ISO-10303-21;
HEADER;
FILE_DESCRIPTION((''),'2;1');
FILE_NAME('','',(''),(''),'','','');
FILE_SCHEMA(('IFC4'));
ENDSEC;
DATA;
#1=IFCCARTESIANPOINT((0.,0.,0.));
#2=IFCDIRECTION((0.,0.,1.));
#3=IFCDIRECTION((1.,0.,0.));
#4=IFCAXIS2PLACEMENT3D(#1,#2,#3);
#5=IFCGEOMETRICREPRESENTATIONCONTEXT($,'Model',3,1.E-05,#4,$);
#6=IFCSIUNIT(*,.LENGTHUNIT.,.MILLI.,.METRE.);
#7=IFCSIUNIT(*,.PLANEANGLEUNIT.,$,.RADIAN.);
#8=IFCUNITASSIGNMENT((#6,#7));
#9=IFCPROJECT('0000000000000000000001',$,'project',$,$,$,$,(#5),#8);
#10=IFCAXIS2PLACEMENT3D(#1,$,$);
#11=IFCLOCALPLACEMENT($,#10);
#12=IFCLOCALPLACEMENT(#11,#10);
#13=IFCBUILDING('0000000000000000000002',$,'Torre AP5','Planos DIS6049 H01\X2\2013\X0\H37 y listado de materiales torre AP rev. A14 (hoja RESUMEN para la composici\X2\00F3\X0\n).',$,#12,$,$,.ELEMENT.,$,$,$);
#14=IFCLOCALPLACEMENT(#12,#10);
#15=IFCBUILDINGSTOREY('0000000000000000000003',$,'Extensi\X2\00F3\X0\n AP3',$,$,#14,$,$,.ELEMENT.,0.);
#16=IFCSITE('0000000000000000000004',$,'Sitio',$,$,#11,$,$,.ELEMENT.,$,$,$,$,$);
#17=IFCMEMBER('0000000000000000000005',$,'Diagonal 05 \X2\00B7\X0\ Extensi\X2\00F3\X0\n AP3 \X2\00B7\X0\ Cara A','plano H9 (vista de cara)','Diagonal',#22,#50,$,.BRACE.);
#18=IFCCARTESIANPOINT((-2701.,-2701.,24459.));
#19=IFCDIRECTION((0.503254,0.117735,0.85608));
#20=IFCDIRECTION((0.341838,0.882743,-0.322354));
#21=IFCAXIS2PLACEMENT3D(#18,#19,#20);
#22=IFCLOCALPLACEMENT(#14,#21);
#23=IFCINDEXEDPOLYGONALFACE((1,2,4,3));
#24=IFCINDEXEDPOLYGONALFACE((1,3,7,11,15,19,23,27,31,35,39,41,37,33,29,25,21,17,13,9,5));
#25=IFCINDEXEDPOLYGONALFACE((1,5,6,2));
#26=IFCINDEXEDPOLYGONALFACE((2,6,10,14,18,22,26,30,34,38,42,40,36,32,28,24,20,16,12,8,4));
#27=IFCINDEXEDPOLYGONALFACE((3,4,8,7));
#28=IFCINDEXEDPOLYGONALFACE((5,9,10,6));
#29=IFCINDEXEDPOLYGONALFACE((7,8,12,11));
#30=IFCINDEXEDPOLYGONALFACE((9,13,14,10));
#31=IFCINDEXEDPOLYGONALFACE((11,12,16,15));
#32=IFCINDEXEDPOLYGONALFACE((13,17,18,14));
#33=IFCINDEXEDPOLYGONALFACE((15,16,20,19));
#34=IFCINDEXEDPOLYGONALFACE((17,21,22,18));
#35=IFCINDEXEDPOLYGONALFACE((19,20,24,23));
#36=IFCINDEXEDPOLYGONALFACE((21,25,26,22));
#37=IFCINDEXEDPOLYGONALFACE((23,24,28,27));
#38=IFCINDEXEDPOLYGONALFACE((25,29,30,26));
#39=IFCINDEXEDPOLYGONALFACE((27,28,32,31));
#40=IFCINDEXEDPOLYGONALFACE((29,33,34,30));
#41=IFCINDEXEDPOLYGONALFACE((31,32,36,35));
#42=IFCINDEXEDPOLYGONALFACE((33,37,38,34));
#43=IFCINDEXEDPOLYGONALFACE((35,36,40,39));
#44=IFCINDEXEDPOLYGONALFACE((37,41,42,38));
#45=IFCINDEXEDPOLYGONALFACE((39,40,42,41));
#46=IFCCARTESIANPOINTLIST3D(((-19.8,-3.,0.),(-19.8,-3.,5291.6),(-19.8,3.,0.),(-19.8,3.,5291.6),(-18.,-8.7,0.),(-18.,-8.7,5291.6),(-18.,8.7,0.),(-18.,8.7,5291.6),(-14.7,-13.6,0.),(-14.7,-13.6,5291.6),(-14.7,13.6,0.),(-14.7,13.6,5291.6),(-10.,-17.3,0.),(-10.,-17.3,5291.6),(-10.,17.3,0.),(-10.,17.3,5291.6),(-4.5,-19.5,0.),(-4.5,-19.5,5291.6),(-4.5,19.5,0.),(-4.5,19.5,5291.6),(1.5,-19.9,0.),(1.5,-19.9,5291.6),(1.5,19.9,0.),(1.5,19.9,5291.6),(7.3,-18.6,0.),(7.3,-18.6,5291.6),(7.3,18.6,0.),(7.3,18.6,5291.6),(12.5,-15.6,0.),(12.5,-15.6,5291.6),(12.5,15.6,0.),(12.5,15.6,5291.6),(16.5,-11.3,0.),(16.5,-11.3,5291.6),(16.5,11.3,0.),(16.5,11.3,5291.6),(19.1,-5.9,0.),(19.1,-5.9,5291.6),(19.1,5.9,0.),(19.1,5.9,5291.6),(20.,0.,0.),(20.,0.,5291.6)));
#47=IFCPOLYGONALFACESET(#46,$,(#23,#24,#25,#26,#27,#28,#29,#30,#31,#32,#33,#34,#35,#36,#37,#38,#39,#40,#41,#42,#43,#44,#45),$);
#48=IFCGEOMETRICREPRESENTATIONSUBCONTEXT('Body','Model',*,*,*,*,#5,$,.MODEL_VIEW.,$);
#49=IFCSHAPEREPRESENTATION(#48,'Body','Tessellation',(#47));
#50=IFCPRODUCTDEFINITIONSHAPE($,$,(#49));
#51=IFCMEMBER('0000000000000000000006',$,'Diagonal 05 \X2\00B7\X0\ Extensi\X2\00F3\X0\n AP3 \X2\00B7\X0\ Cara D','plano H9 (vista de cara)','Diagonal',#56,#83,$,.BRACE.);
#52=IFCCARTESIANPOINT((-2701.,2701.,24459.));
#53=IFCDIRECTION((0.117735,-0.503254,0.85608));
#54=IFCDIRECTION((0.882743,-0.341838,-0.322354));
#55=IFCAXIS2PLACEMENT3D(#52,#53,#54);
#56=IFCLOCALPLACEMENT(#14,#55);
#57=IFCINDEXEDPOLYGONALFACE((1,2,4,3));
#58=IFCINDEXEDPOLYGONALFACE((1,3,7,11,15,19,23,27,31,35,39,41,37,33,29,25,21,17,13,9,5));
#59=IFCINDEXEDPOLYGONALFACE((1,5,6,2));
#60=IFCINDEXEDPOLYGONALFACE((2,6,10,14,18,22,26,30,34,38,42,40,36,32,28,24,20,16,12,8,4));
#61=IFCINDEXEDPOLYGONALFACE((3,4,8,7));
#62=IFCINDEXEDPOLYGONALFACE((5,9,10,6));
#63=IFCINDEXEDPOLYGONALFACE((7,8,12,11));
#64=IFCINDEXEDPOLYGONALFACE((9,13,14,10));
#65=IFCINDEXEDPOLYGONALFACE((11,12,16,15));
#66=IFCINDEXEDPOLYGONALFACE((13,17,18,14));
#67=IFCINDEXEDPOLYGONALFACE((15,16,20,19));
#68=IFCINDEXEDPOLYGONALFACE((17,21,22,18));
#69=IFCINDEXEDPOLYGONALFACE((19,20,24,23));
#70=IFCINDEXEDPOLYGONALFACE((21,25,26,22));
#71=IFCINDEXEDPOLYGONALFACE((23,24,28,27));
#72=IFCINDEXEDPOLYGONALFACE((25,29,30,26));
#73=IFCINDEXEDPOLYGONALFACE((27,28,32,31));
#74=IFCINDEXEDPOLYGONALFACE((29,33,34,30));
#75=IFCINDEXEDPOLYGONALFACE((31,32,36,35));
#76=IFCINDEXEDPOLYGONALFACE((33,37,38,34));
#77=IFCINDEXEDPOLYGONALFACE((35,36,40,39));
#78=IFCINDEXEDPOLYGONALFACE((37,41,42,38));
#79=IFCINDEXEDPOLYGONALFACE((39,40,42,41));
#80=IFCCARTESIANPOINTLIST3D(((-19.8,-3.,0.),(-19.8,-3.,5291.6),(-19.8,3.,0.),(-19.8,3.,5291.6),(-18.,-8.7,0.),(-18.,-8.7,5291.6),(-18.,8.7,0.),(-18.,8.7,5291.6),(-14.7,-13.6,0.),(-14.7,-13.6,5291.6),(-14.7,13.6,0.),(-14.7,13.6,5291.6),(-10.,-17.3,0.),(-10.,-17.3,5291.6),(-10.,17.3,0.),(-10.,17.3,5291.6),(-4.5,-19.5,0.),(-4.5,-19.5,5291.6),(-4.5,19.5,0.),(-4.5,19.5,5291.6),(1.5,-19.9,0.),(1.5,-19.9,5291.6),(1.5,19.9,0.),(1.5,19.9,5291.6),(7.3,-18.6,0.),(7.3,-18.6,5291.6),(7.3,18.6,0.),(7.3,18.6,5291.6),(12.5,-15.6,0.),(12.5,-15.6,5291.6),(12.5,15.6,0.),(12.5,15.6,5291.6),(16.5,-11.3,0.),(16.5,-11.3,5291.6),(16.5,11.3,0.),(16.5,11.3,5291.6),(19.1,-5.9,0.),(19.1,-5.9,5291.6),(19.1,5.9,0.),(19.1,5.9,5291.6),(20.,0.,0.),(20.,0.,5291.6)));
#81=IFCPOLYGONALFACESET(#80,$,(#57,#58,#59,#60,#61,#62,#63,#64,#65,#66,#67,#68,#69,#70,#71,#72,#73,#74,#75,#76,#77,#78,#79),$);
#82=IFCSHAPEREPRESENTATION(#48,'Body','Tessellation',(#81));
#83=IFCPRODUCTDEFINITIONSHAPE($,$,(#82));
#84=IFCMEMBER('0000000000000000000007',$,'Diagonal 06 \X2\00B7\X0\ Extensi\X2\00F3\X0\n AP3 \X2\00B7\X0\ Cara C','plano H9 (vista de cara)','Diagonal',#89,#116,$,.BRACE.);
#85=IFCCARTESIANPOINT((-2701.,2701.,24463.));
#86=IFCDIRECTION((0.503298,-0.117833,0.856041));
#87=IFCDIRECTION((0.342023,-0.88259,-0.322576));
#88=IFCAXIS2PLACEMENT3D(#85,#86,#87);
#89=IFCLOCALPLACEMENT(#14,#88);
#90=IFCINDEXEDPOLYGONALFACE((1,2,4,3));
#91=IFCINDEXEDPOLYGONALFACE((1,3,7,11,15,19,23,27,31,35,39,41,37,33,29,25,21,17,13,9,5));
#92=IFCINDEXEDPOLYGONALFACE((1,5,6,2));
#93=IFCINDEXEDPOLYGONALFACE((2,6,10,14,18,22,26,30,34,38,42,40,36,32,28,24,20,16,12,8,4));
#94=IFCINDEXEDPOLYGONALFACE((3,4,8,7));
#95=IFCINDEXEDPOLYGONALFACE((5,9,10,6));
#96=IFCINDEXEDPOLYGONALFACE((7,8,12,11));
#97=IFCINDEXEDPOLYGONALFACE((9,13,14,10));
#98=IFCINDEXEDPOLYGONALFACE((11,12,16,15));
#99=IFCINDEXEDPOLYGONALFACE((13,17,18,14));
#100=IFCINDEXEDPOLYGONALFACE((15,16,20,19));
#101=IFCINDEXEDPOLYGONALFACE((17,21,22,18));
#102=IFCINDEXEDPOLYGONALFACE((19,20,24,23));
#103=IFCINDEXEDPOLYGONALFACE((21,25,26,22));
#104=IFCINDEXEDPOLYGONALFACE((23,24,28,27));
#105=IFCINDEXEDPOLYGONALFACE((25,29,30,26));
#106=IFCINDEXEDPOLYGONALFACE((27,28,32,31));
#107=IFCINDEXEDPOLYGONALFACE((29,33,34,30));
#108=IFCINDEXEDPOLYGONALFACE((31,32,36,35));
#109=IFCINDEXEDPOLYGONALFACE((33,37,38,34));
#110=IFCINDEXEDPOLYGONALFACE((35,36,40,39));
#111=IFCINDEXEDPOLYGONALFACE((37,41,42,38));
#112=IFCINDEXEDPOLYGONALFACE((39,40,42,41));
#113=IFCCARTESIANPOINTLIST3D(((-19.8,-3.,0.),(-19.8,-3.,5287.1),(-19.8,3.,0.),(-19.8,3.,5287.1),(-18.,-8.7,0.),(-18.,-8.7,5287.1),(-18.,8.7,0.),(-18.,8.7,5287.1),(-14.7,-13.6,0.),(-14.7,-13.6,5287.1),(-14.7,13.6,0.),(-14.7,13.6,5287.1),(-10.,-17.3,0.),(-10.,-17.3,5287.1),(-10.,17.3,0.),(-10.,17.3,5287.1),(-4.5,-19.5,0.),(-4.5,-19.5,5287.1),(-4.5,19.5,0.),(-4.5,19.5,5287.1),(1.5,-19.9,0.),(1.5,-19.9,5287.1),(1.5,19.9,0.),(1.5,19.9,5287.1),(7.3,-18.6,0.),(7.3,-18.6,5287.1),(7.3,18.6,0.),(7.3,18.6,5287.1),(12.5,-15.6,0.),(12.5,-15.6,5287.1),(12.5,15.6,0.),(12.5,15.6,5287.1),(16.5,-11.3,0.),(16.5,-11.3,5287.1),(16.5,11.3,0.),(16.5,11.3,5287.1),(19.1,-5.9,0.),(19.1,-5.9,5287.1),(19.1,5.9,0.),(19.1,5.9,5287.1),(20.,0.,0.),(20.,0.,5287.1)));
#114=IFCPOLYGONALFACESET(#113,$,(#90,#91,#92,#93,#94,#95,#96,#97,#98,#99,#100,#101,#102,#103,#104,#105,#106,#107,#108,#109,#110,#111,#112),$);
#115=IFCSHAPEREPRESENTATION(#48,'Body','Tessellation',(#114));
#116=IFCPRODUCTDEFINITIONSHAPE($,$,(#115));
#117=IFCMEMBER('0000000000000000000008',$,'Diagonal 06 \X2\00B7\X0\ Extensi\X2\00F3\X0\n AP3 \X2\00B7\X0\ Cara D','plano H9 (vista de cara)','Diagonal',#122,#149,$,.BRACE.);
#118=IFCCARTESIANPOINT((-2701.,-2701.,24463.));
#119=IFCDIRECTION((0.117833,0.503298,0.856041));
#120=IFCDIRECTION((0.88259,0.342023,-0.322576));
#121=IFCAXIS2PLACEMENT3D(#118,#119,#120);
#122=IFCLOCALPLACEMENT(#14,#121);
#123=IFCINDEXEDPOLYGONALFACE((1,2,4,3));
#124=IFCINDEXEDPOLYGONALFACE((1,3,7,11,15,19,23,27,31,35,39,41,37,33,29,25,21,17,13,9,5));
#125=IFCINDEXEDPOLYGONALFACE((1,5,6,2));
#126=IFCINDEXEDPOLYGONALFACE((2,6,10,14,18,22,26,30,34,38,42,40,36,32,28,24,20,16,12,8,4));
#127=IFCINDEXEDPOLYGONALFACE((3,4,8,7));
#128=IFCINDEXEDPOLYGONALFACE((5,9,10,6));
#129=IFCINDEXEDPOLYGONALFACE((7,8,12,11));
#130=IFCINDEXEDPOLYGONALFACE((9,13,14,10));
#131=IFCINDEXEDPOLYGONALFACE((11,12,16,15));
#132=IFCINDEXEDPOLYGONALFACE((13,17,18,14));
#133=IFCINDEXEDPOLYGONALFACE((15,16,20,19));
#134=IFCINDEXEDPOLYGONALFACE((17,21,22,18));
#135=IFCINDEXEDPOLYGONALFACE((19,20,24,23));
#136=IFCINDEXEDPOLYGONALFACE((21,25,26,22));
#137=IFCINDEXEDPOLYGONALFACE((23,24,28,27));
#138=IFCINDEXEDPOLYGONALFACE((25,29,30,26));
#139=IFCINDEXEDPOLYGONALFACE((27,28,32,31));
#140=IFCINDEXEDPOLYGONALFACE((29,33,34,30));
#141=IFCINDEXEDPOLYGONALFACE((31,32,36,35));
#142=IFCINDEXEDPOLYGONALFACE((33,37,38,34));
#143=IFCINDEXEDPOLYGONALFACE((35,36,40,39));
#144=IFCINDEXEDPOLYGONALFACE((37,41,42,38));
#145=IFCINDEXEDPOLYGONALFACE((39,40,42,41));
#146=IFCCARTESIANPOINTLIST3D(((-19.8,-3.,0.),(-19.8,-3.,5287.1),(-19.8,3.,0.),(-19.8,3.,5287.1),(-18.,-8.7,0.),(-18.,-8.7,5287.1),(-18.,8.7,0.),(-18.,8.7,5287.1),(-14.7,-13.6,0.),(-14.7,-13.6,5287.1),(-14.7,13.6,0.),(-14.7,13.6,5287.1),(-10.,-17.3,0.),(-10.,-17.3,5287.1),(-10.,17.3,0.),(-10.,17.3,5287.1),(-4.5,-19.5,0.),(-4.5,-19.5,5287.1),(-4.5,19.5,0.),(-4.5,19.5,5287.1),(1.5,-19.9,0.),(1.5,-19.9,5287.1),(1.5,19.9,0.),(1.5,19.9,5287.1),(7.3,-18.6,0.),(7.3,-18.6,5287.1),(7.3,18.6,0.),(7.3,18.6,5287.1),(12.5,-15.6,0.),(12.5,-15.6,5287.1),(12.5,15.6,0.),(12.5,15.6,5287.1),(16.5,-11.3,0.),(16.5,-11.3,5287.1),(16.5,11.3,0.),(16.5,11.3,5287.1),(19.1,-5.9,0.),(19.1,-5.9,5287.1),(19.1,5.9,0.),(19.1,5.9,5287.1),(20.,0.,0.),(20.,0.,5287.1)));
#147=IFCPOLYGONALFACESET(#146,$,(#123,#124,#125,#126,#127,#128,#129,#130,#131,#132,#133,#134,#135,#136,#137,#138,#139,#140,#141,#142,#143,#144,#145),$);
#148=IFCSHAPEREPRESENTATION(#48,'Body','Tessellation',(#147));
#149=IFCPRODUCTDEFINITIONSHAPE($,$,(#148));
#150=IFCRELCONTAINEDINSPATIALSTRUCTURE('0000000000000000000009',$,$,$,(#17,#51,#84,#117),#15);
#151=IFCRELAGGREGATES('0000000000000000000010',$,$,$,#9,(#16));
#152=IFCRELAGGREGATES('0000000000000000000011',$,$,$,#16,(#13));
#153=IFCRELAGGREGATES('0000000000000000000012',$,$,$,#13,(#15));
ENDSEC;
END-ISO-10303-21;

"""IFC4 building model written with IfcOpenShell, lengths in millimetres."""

from ifc_helpers import new_model, si_unit, frame, origin, origin_with_axes, place, context, subcontext, project, spatial, circle, extrude, element, save


model = new_model("IFC4")

# Units and contexts
model_context = context("Model", 3, precision=1e-05, world=origin_with_axes())
body_context = subcontext(model_context, "Body", "Model", "MODEL_VIEW")
ifc_project = project(units=[si_unit("LENGTHUNIT", "METRE", prefix="MILLI"), si_unit("PLANEANGLEUNIT", "RADIAN")], contexts=[model_context])

# Site, building, storey
site_placement = place(None, origin())
site = spatial("IfcSite", under=ifc_project, at=site_placement, Name="Sitio", CompositionType="ELEMENT")
building_placement = place(site_placement, origin())
building = spatial("IfcBuilding", under=site, at=building_placement, Name="Torre AP5", Description="Planos DIS6049 H01–H37 y listado de materiales torre AP rev. A14 (hoja RESUMEN para la composición).", CompositionType="ELEMENT")
storey_placement = place(building_placement, origin())
storey = spatial("IfcBuildingStorey", under=building, at=storey_placement, Name="Extensión AP3", CompositionType="ELEMENT", Elevation=0.0)

# Members
for number, where, z_axis, x_axis, name in (
    (1, (-2701.0, -2701.0, 24459.0), (0.503254, 0.117735, 0.85608), (0.341838, 0.882743, -0.322354), "Diagonal 05 · Extensión AP3 · Cara A"),
    (2, (-2701.0, 2701.0, 24459.0), (0.117735, -0.503254, 0.85608), (0.882743, -0.341838, -0.322354), "Diagonal 05 · Extensión AP3 · Cara D"),
):
    element("IfcMember", number, at=place(storey_placement, frame(where, z_axis=z_axis, x_axis=x_axis)), inside=storey, Name=name, Description="plano H9 (vista de cara)", ObjectType="Diagonal", PredefinedType="BRACE", context=body_context, shape_type="SweptSolid", body=[
        extrude(circle(Radius=20.0), None, (0.0, 0.0, 1.0), 5291.6),
    ])
for number, where, z_axis, x_axis, name in (
    (3, (-2701.0, 2701.0, 24463.0), (0.503298, -0.117833, 0.856041), (0.342023, -0.88259, -0.322576), "Diagonal 06 · Extensión AP3 · Cara C"),
    (4, (-2701.0, -2701.0, 24463.0), (0.117833, 0.503298, 0.856041), (0.88259, 0.342023, -0.322576), "Diagonal 06 · Extensión AP3 · Cara D"),
):
    element("IfcMember", number, at=place(storey_placement, frame(where, z_axis=z_axis, x_axis=x_axis)), inside=storey, Name=name, Description="plano H9 (vista de cara)", ObjectType="Diagonal", PredefinedType="BRACE", context=body_context, shape_type="SweptSolid", body=[
        extrude(circle(Radius=20.0), None, (0.0, 0.0, 1.0), 5287.1),
    ])

save(model, "model.ifc")
